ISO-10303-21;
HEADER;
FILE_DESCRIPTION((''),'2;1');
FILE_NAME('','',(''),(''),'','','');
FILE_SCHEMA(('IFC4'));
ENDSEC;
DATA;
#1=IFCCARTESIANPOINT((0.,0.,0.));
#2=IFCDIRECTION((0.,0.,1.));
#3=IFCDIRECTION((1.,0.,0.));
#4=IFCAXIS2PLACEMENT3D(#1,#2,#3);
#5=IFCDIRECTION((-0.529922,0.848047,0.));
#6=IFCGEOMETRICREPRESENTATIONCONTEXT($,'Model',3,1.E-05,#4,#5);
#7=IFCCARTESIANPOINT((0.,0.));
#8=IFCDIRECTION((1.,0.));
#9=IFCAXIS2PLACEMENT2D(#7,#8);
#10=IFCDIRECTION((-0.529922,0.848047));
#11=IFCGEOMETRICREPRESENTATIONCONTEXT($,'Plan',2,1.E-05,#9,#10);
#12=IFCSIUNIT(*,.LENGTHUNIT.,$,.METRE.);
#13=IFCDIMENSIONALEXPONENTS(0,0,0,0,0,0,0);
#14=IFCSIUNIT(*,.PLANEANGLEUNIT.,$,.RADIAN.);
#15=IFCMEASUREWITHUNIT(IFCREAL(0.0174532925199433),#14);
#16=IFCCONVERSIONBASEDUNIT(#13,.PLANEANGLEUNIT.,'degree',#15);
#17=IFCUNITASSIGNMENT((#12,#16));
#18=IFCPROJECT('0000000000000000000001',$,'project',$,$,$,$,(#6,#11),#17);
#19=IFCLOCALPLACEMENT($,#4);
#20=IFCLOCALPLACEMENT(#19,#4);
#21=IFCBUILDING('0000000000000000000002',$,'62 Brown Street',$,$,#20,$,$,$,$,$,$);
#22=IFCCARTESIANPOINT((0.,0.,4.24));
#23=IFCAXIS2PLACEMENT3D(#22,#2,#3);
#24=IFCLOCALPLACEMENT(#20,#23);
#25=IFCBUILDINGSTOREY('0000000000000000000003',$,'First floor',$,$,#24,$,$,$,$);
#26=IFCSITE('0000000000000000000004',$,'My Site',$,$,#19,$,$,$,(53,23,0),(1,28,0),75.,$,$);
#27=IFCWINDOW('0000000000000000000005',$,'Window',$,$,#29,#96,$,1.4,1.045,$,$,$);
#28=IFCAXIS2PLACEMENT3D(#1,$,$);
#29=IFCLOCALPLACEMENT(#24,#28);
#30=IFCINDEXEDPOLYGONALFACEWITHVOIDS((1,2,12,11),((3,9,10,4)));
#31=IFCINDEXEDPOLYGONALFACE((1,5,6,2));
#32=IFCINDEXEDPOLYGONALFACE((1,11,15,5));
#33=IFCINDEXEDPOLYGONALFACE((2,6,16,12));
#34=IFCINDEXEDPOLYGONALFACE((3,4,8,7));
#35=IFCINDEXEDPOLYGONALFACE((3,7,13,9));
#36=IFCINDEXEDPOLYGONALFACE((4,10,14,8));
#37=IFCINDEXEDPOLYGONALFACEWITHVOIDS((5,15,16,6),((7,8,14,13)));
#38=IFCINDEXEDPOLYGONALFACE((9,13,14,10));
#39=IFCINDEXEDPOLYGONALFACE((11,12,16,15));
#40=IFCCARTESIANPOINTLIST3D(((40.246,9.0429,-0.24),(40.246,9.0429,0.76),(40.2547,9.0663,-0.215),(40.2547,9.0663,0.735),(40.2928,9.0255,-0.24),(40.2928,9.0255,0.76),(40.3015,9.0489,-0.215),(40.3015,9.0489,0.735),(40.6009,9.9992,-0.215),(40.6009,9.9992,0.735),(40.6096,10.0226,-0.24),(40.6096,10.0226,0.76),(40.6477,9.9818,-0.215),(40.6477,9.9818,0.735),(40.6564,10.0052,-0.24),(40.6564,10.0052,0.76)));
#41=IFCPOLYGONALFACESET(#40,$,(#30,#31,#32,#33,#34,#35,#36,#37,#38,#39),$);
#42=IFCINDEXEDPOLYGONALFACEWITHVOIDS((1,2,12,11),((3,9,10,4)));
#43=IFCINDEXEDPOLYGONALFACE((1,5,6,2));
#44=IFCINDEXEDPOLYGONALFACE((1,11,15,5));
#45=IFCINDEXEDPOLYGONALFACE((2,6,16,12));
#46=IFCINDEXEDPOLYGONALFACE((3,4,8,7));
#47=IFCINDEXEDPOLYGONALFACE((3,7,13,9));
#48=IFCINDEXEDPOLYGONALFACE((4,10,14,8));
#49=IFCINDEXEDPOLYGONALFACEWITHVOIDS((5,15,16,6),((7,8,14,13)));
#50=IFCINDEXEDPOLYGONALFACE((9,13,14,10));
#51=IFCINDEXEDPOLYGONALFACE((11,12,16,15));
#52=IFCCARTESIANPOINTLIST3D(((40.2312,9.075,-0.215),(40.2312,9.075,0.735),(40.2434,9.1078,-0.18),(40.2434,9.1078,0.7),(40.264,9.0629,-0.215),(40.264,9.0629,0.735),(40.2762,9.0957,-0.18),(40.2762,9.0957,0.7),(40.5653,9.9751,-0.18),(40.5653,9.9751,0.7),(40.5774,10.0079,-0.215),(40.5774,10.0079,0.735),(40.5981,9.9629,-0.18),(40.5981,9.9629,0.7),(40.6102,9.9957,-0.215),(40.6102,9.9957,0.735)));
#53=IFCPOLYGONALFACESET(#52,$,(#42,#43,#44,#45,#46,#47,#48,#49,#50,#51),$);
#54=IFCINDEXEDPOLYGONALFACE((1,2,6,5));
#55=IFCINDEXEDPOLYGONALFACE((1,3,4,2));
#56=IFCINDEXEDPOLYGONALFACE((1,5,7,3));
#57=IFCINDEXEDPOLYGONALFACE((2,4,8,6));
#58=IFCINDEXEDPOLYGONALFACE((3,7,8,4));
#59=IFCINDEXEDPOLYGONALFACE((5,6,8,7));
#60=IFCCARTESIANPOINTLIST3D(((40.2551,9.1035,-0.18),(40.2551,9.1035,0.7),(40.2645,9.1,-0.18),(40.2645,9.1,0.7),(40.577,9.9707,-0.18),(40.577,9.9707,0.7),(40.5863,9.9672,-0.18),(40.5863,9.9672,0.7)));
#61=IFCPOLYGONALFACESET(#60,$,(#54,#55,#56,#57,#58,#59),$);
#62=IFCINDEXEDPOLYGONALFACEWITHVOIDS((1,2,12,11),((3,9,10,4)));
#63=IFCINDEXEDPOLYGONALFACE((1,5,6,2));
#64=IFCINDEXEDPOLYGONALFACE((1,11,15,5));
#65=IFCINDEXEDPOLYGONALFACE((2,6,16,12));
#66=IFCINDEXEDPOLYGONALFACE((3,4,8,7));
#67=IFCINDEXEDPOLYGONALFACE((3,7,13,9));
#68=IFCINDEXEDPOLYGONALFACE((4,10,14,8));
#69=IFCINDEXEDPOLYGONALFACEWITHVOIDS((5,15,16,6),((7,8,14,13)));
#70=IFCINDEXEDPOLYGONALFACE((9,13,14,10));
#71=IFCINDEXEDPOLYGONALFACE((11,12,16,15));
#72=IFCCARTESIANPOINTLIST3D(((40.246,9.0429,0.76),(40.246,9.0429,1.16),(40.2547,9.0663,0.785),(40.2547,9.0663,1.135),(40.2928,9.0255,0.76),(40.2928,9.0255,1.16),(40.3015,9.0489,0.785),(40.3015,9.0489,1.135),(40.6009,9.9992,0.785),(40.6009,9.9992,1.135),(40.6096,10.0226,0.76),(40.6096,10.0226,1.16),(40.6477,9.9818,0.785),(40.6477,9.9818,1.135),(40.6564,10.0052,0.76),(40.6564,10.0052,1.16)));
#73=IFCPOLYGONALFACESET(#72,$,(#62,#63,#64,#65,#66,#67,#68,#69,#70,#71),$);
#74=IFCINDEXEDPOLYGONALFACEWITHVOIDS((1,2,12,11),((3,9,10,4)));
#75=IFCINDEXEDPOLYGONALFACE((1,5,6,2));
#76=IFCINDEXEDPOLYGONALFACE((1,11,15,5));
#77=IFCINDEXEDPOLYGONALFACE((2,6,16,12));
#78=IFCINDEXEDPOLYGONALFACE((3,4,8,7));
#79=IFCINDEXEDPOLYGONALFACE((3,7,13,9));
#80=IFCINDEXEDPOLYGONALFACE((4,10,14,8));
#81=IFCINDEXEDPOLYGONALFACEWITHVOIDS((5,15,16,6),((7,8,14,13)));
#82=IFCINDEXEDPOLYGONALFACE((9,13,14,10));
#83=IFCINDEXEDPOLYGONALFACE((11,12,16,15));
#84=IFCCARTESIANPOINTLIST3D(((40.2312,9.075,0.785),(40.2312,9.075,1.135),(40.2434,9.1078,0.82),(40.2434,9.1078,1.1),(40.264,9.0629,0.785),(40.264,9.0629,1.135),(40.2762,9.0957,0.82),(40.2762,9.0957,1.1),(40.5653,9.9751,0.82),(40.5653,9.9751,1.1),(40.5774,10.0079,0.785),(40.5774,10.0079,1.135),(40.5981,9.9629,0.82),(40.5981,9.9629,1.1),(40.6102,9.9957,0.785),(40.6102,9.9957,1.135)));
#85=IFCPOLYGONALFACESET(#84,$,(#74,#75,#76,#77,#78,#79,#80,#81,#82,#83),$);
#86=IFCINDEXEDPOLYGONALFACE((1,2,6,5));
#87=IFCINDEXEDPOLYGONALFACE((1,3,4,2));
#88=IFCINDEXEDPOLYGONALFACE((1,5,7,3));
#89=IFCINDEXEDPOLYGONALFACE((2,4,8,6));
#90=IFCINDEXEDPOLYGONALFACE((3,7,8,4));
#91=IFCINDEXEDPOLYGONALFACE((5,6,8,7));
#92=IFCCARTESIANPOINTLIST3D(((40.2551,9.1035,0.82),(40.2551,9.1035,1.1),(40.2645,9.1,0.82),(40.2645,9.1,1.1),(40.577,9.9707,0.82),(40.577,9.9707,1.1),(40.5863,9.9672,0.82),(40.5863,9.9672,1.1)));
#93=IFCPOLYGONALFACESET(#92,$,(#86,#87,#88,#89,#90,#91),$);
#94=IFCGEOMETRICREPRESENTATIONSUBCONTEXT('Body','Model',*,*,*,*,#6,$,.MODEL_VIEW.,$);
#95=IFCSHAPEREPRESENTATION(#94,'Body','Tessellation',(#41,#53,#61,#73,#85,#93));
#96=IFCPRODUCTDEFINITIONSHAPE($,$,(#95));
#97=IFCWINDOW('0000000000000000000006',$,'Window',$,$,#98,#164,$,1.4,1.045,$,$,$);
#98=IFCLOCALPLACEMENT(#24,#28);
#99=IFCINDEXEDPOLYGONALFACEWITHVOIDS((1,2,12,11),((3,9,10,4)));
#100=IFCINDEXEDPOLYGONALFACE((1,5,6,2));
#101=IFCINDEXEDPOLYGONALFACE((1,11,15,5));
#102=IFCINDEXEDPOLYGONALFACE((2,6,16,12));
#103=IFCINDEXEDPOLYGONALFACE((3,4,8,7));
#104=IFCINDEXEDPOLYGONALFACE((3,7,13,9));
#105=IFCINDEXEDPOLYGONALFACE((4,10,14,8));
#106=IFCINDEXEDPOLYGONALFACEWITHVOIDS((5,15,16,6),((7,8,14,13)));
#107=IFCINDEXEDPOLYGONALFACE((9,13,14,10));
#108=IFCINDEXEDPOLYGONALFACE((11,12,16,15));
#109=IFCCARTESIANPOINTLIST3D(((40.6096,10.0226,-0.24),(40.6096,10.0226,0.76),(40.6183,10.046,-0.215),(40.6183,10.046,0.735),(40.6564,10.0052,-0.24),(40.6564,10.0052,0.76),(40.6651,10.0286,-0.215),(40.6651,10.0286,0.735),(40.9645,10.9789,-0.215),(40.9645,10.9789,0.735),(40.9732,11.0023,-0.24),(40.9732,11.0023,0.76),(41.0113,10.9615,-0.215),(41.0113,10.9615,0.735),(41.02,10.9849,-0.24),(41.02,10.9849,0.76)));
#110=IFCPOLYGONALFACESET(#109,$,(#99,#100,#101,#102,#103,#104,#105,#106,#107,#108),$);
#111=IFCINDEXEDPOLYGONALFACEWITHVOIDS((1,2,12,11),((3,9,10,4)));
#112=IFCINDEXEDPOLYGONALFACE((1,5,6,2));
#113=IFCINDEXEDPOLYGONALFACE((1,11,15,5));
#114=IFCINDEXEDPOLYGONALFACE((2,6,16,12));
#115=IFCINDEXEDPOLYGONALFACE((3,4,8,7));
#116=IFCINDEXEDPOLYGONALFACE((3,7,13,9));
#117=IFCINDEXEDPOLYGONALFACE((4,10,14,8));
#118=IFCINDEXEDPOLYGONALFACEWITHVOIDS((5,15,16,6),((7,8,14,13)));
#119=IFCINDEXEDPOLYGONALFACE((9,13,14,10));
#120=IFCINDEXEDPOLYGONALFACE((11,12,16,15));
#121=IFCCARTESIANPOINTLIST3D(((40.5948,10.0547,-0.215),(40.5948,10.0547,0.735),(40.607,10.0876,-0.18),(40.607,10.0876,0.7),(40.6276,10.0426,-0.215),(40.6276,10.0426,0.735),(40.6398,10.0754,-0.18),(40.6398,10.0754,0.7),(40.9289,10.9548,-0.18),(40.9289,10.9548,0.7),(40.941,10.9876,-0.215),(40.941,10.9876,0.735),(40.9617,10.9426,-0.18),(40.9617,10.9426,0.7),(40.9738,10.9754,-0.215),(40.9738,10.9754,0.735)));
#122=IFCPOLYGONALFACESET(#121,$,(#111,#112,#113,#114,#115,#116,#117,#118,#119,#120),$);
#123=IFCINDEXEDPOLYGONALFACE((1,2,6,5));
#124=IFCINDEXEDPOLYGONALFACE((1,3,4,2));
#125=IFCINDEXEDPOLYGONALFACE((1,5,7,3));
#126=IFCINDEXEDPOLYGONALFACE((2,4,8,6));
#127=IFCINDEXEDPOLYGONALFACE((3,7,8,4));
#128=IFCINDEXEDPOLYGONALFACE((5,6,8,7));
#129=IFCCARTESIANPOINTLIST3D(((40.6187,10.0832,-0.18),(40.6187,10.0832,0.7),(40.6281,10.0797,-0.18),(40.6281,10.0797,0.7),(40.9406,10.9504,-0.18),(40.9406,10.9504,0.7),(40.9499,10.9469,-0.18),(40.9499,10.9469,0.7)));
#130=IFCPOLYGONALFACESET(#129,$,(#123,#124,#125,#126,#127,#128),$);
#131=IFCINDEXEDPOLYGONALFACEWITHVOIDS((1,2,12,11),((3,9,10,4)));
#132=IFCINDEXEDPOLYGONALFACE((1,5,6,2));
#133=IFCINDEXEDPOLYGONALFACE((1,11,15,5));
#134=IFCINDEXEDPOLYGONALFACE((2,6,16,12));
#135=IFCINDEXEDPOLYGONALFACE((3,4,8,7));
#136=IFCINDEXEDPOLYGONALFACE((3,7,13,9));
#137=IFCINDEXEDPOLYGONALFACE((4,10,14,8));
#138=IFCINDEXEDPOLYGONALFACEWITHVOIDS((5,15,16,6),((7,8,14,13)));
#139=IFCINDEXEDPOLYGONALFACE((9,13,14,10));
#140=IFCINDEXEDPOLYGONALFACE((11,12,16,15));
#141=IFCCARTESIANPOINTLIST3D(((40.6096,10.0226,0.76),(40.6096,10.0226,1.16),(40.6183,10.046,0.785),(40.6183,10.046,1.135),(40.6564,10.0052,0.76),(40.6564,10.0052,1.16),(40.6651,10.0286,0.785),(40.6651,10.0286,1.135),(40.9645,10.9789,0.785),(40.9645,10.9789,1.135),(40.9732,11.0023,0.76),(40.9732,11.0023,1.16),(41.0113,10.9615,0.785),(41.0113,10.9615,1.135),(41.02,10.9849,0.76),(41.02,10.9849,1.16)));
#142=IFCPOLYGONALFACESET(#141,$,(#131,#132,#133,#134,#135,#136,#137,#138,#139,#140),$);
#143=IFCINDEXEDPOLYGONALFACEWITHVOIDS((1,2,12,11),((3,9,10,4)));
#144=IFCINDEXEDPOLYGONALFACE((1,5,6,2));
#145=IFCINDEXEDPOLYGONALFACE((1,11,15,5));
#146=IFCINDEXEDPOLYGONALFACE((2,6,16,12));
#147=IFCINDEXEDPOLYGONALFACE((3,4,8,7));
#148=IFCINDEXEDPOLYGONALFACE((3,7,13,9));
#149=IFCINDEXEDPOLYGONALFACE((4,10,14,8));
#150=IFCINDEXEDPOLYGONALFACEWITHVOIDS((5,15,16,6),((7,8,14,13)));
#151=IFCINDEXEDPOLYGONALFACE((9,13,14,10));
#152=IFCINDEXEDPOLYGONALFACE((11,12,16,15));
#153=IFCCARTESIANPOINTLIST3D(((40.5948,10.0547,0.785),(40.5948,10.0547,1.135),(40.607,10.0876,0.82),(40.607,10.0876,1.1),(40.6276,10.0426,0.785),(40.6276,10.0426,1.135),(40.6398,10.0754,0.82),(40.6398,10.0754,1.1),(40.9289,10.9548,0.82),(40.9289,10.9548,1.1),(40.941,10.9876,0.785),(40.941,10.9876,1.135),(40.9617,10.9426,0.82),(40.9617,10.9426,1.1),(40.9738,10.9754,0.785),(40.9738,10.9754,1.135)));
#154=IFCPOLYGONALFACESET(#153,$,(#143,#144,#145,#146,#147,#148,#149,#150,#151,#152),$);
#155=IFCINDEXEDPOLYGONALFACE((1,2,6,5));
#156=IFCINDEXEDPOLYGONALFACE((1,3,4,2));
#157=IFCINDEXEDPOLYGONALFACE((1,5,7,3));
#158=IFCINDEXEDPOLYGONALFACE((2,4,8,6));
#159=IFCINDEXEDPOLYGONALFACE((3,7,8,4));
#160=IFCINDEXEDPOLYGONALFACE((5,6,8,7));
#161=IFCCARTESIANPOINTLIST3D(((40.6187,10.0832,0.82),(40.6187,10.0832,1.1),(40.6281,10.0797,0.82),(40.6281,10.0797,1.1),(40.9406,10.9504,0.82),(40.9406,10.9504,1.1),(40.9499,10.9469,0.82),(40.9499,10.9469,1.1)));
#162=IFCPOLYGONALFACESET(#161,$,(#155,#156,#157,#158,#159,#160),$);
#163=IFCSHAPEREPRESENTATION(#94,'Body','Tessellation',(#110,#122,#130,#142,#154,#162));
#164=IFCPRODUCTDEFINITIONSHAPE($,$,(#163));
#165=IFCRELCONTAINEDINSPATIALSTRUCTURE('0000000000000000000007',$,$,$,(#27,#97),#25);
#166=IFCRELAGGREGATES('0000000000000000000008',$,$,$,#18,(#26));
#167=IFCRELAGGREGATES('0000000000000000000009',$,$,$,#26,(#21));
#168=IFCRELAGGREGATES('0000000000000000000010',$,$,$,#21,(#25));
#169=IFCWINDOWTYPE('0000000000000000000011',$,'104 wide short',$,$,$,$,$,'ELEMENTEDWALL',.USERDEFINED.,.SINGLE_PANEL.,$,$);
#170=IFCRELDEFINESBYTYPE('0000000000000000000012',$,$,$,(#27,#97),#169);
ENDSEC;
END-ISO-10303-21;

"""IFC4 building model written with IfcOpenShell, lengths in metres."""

from ifc_helpers import new_model, entity, si_unit, converted_unit, direction, frame, origin_with_axes, origin_2d_with_axis, place, context, subcontext, project, spatial, line, indexed_curve, outline, extrude, shape, source, transform, mapped, type_object, type_shapes, element, save


model = new_model("IFC4")

# Units and contexts
model_context = context("Model", 3, precision=1e-05, world=origin_with_axes(), true_north=direction((-0.529922, 0.848047, 0.0)))
plan_context = context("Plan", 2, precision=1e-05, world=origin_2d_with_axis(), true_north=direction((-0.529922, 0.848047)))
body_context_1 = subcontext(model_context, "Body", "Model", "MODEL_VIEW")
body_context_2 = subcontext(plan_context, "Body", "Plan", "PLAN_VIEW")
ifc_project = project(units=[si_unit("LENGTHUNIT", "METRE"), converted_unit("PLANEANGLEUNIT", "degree", entity("IfcReal", 0.0174532925199433), si_unit("PLANEANGLEUNIT", "RADIAN"), dimensions=[0, 0, 0, 0, 0, 0, 0])], contexts=[model_context, plan_context])

# Site, building, storey
site_placement = place(None, origin_with_axes())
site = spatial("IfcSite", under=ifc_project, at=site_placement, Name="My Site", RefLatitude=(53, 23, 0), RefLongitude=(1, 28, 0), RefElevation=75.0)
building_placement = place(site_placement, origin_with_axes())
building = spatial("IfcBuilding", under=site, at=building_placement, Name="62 Brown Street")
storey_placement = place(building_placement, frame((0.0, 0.0, 4.24), z_axis=(0.0, 0.0, 1.0), x_axis=(1.0, 0.0, 0.0)))
storey = spatial("IfcBuildingStorey", under=building, at=storey_placement, Name="First floor")

# Shared definitions
window_type_1 = type_object("IfcWindowType", Name="104 wide short", ElementType="ELEMENTEDWALL", PartitioningType="SINGLE_PANEL", PredefinedType="USERDEFINED")
shared_shape_1 = source(origin_with_axes(), body_context_1, "Body", "SweptSolid", [
    extrude(outline(indexed_curve([(0.0, 0.0), (1.045, 0.0), (1.045, 1.0), (0.0, 1.0)], segments=[line(1, 2, 3, 4, 1)]), holes=[indexed_curve([(0.025, 0.025), (1.02, 0.025), (1.02, 0.975), (0.025, 0.975)], segments=[line(1, 2, 3, 4, 1)])]), frame((0.0, 0.15, 0.0), z_axis=(0.0, -1.0, 0.0), x_axis=(1.0, 0.0, 0.0)), (0.0, 0.0, -1.0), 0.05),
    extrude(outline(indexed_curve([(0.0, 0.0), (0.995, 0.0), (0.995, 0.95), (0.0, 0.95)], segments=[line(1, 2, 3, 4, 1)]), holes=[indexed_curve([(0.035, 0.035), (0.96, 0.035), (0.96, 0.915), (0.035, 0.915)], segments=[line(1, 2, 3, 4, 1)])]), frame((0.025, 0.19, 0.025), z_axis=(0.0, -1.0, 0.0), x_axis=(1.0, 0.0, 0.0)), (0.0, 0.0, -1.0), 0.035),
    extrude(outline(indexed_curve([(0.035, 0.035), (0.96, 0.035), (0.96, 0.915), (0.035, 0.915)], segments=[line(1, 2, 3, 4, 1)])), frame((0.025, 0.2025, 0.025), z_axis=(0.0, -1.0, 0.0), x_axis=(1.0, 0.0, 0.0)), (0.0, 0.0, -1.0), 0.01),
    extrude(outline(indexed_curve([(0.0, 0.0), (1.045, 0.0), (1.045, 0.4), (0.0, 0.4)], segments=[line(1, 2, 3, 4, 1)]), holes=[indexed_curve([(0.025, 0.025), (1.02, 0.025), (1.02, 0.375), (0.025, 0.375)], segments=[line(1, 2, 3, 4, 1)])]), frame((0.0, 0.15, 1.0), z_axis=(0.0, -1.0, 0.0), x_axis=(1.0, 0.0, 0.0)), (0.0, 0.0, -1.0), 0.05),
    extrude(outline(indexed_curve([(0.0, 0.0), (0.995, 0.0), (0.995, 0.35), (0.0, 0.35)], segments=[line(1, 2, 3, 4, 1)]), holes=[indexed_curve([(0.035, 0.035), (0.96, 0.035), (0.96, 0.315), (0.035, 0.315)], segments=[line(1, 2, 3, 4, 1)])]), frame((0.025, 0.19, 1.025), z_axis=(0.0, -1.0, 0.0), x_axis=(1.0, 0.0, 0.0)), (0.0, 0.0, -1.0), 0.035),
    extrude(outline(indexed_curve([(0.035, 0.035), (0.96, 0.035), (0.96, 0.315), (0.035, 0.315)], segments=[line(1, 2, 3, 4, 1)])), frame((0.025, 0.2025, 1.025), z_axis=(0.0, -1.0, 0.0), x_axis=(1.0, 0.0, 0.0)), (0.0, 0.0, -1.0), 0.01),
])
shared_shape_2 = source(origin_with_axes(), body_context_2, "Body", "Curve2D", [
    entity("IfcIndexedPolyCurve", entity("IfcCartesianPointList2D", [[0.025, 0.15], [1.02, 0.15]])),
    entity("IfcIndexedPolyCurve", entity("IfcCartesianPointList2D", [[0.0, 0.2], [0.025, 0.2], [0.025, 0.15], [0.0, 0.15]]), [entity("IfcLineIndex", [1, 2, 3, 4, 1])]),
    entity("IfcIndexedPolyCurve", entity("IfcCartesianPointList2D", [[1.045, 0.2], [1.02, 0.2], [1.02, 0.15], [1.045, 0.15]]), [entity("IfcLineIndex", [1, 2, 3, 4, 1])]),
    entity("IfcIndexedPolyCurve", entity("IfcCartesianPointList2D", [[0.025, 0.19], [0.06, 0.19], [0.06, 0.225], [0.025, 0.225]]), [entity("IfcLineIndex", [1, 2, 3, 4, 1])]),
    entity("IfcIndexedPolyCurve", entity("IfcCartesianPointList2D", [[1.02, 0.19], [0.985, 0.19], [0.985, 0.225], [1.02, 0.225]]), [entity("IfcLineIndex", [1, 2, 3, 4, 1])]),
    entity("IfcIndexedPolyCurve", entity("IfcCartesianPointList2D", [[0.06, 0.19], [0.985, 0.19]])),
    entity("IfcIndexedPolyCurve", entity("IfcCartesianPointList2D", [[0.06, 0.225], [0.985, 0.225]])),
    entity("IfcIndexedPolyCurve", entity("IfcCartesianPointList2D", [[0.06, 0.2075], [0.985, 0.2075]])),
])
type_shapes(window_type_1, [shared_shape_1, shared_shape_2])

# Windows
for number, where, z_axis, x_axis, name in (
    (1, (40.4335, 8.9733, -0.24), (0.0, 0.0, 1.0), (0.347944, 0.937515, 0.0), "Window"),
    (2, (40.7971, 9.953, -0.24), (0.0, 0.0, 1.0), (0.347944, 0.937515, 0.0), "Window"),
):
    element("IfcWindow", number, at=place(storey_placement, frame(where, z_axis=z_axis, x_axis=x_axis)), inside=storey, type_object=window_type_1, Name=name, OverallHeight=1.4, OverallWidth=1.045, shapes=[
        shape(body_context_1, "Body", "MappedRepresentation", [mapped(shared_shape_1, transform((0.0, 0.0, 0.0), x_axis=(1.0, 0.0, 0.0), y_axis=(0.0, 1.0, 0.0), z_axis=(0.0, 0.0, 1.0), scale=1.0))]),
        shape(body_context_2, "Body", "MappedRepresentation", [mapped(shared_shape_2, transform((0.0, 0.0, 0.0), x_axis=(1.0, 0.0, 0.0), y_axis=(0.0, 1.0, 0.0), z_axis=(0.0, 0.0, 1.0), scale=1.0))]),
    ])

save(model, "model.ifc")
